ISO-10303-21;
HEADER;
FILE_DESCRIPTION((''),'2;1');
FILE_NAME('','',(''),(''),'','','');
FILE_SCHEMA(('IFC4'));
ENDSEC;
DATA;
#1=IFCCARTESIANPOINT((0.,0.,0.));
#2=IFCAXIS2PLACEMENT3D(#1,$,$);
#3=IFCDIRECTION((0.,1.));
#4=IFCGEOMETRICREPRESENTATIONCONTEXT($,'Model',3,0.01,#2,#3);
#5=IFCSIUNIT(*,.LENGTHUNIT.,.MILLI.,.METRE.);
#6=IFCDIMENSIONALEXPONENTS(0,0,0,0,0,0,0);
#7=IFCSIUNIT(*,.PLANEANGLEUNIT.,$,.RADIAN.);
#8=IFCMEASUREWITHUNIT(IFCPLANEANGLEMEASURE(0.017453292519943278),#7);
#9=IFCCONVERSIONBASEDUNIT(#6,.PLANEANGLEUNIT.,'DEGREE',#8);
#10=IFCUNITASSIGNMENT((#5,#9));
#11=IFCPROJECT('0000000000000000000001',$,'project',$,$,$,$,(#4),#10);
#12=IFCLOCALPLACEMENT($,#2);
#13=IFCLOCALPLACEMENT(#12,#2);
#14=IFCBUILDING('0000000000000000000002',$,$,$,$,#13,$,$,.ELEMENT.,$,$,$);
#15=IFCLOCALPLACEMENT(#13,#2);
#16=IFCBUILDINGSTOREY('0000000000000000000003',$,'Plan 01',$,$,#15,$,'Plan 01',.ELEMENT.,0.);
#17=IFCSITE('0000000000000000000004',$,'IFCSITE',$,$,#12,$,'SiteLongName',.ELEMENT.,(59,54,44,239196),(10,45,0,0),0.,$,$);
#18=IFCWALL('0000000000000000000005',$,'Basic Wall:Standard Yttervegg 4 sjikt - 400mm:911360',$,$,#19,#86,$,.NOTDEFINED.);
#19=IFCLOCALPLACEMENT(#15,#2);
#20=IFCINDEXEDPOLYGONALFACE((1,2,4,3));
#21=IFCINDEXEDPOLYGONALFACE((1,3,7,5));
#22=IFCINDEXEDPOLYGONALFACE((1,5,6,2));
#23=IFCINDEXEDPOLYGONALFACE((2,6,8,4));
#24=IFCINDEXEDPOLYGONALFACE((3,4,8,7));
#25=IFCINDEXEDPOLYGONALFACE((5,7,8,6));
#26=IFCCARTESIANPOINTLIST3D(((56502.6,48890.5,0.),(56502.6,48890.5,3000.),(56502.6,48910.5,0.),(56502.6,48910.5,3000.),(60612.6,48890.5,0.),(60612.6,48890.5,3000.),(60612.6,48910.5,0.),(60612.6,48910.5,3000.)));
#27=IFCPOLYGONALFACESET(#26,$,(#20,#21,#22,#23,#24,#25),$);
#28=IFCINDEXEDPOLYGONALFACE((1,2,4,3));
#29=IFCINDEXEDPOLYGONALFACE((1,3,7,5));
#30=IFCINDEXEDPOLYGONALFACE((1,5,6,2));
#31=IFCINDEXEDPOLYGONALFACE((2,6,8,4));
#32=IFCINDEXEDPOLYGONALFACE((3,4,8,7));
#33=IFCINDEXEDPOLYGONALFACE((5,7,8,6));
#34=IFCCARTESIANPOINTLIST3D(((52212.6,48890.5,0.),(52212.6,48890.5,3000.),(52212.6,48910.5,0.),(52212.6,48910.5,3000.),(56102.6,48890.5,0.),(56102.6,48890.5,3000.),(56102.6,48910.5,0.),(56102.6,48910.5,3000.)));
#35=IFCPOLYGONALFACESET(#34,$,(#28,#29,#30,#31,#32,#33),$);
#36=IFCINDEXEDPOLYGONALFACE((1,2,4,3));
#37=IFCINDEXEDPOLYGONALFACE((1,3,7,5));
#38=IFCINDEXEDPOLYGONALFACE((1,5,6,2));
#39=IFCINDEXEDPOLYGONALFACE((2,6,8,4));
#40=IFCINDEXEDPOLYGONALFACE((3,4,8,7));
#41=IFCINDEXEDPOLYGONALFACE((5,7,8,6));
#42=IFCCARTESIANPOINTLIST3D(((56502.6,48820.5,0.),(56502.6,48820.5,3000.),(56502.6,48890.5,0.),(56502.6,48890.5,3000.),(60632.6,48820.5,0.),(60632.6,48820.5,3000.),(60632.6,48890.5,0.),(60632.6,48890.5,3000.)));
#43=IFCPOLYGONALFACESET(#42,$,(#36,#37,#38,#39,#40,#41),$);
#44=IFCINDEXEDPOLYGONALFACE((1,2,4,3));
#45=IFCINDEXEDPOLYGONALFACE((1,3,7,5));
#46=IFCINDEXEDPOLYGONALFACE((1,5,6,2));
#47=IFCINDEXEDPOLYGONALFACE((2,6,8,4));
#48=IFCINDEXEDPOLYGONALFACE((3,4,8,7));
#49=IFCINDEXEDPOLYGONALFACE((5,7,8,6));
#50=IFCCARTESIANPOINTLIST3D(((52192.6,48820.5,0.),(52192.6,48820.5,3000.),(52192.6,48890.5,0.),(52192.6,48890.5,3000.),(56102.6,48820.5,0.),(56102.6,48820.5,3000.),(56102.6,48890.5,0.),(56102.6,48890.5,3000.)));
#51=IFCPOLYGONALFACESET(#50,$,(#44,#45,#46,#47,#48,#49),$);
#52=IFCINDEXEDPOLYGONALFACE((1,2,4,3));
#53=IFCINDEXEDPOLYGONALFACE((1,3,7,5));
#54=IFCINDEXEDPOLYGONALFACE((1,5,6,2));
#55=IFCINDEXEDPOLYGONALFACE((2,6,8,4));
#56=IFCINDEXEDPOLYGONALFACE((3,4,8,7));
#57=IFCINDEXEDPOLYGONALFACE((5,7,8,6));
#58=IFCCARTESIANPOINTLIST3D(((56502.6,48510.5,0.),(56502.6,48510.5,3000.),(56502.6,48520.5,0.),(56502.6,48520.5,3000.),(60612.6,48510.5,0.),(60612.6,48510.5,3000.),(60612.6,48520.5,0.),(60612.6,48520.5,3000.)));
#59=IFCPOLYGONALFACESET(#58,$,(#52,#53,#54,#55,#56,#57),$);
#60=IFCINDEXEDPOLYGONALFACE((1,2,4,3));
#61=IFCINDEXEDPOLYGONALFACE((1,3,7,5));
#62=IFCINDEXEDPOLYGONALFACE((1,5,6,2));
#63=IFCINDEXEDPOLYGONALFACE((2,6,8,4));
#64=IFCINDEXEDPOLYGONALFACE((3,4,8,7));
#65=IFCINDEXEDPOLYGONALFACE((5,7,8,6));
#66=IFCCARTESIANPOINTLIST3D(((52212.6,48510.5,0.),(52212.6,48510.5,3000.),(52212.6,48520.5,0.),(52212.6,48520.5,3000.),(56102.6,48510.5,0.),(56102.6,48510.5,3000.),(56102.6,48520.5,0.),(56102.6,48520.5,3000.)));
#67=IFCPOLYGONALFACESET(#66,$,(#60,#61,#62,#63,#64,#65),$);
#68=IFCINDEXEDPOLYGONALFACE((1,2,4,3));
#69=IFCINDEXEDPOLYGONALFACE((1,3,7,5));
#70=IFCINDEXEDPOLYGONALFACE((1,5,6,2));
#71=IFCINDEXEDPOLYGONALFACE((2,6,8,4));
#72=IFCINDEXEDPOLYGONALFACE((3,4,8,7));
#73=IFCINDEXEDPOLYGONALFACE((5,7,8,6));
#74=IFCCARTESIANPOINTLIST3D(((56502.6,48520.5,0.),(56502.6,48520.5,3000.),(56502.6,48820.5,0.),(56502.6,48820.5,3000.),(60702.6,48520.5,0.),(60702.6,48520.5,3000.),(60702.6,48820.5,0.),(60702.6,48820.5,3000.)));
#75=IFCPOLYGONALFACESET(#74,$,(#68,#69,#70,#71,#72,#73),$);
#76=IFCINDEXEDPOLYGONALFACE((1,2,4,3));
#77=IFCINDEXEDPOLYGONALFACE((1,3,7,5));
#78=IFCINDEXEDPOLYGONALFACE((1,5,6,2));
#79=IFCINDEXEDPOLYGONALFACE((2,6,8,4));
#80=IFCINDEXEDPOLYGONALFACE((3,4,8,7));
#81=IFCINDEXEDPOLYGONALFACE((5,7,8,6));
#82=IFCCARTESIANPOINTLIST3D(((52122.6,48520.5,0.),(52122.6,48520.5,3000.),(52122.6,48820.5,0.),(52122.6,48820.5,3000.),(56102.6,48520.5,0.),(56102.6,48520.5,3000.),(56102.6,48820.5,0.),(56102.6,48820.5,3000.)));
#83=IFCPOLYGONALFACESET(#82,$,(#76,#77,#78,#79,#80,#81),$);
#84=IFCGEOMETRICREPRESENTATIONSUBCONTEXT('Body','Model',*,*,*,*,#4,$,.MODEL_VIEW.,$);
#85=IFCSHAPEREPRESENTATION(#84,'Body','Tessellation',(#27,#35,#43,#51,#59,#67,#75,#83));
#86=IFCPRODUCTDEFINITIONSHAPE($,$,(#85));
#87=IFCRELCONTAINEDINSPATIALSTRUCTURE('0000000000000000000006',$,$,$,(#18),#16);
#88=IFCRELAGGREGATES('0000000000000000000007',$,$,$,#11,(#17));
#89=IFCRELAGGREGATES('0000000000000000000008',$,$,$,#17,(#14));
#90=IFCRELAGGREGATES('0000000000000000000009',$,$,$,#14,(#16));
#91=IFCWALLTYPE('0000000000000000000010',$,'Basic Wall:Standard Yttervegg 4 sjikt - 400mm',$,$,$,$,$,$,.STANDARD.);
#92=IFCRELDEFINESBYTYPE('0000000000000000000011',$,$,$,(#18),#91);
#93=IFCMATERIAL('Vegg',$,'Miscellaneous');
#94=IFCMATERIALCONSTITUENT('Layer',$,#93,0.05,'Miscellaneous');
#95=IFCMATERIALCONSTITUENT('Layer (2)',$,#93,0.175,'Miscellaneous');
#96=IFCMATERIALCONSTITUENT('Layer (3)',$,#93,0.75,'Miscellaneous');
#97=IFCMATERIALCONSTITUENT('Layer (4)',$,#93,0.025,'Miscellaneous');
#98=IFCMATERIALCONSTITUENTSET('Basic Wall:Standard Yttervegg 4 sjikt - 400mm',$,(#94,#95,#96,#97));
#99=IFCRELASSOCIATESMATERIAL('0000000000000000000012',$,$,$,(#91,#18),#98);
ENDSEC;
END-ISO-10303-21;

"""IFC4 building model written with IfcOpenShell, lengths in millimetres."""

from ifc_helpers import new_model, entity, si_unit, converted_unit, direction, frame, origin, place, context, subcontext, project, spatial, indexed_curve, outline, extrude, material, constituent, constituent_set, type_object, element, save


model = new_model("IFC4")

# Units and contexts
model_context = context("Model", 3, precision=0.01, world=origin(), true_north=direction((0.0, 1.0)))
body_context = subcontext(model_context, "Body", "Model", "MODEL_VIEW")
ifc_project = project(units=[si_unit("LENGTHUNIT", "METRE", prefix="MILLI"), converted_unit("PLANEANGLEUNIT", "DEGREE", entity("IfcPlaneAngleMeasure", 0.017453292519943278), si_unit("PLANEANGLEUNIT", "RADIAN"), dimensions=[0, 0, 0, 0, 0, 0, 0])], contexts=[model_context])

# Site, building, storey
site_placement = place(None, origin())
site = spatial("IfcSite", under=ifc_project, at=site_placement, Name="IFCSITE", LongName="SiteLongName", CompositionType="ELEMENT", RefLatitude=(59, 54, 44, 239196), RefLongitude=(10, 45, 0, 0), RefElevation=0.0)
building_placement = place(site_placement, origin())
building = spatial("IfcBuilding", under=site, at=building_placement, CompositionType="ELEMENT")
storey_placement = place(building_placement, origin())
storey = spatial("IfcBuildingStorey", under=building, at=storey_placement, Name="Plan 01", LongName="Plan 01", CompositionType="ELEMENT", Elevation=0.0)

# Wall
ifc_material_1 = material(Name="Vegg", Category="Miscellaneous")
ifc_constituent_1 = constituent(ifc_material_1, Name="Layer", Category="Miscellaneous", fraction=0.05)
ifc_constituent_2 = constituent(ifc_material_1, Name="Layer (2)", Category="Miscellaneous", fraction=0.175)
ifc_constituent_3 = constituent(ifc_material_1, Name="Layer (3)", Category="Miscellaneous", fraction=0.75)
ifc_constituent_4 = constituent(ifc_material_1, Name="Layer (4)", Category="Miscellaneous", fraction=0.025)
ifc_constituent_set_1 = constituent_set(constituents=[ifc_constituent_1, ifc_constituent_2, ifc_constituent_3, ifc_constituent_4], Name="Basic Wall:Standard Yttervegg 4 sjikt - 400mm")
wall_type = type_object("IfcWallType", Name="Basic Wall:Standard Yttervegg 4 sjikt - 400mm", PredefinedType="STANDARD", material=ifc_constituent_set_1)
wall_1_placement = place(storey_placement, frame((52212.6, 48710.5, 0.0)))
element("IfcWall", 1, at=wall_1_placement, inside=storey, type_object=wall_type, material=ifc_constituent_set_1, Name="Basic Wall:Standard Yttervegg 4 sjikt - 400mm:911360", PredefinedType="NOTDEFINED", context=body_context, shape_type="SweptSolid", body=[
    extrude(outline(indexed_curve([(-10.0, -2055.0), (10.0, -2055.0), (10.0, 2055.0), (-10.0, 2055.0), (-10.0, -2055.0)], self_intersect=False)), frame((6345.0, 190.0, 0.0), z_axis=(0.0, 0.0, 1.0), x_axis=(0.0, -1.0, 0.0)), (0.0, 0.0, 1.0), 3000.0),
    extrude(outline(indexed_curve([(-10.0, -1945.0), (10.0, -1945.0), (10.0, 1945.0), (-10.0, 1945.0), (-10.0, -1945.0)], self_intersect=False)), frame((1945.0, 190.0, 0.0), z_axis=(0.0, 0.0, 1.0), x_axis=(0.0, -1.0, 0.0)), (0.0, 0.0, 1.0), 3000.0),
    extrude(outline(indexed_curve([(-2065.0, -35.0), (2065.0, -35.0), (2065.0, 35.0), (-2065.0, 35.0), (-2065.0, -35.0)], self_intersect=False)), frame((6355.0, 145.0, 0.0), z_axis=(0.0, 0.0, 1.0), x_axis=(-1.0, 0.0, 0.0)), (0.0, 0.0, 1.0), 3000.0),
    extrude(outline(indexed_curve([(-1955.0, -35.0), (1955.0, -35.0), (1955.0, 35.0), (-1955.0, 35.0), (-1955.0, -35.0)], self_intersect=False)), frame((1935.0, 145.0, 0.0)), (0.0, 0.0, 1.0), 3000.0),
    extrude(outline(indexed_curve([(-5.0, -2055.0), (5.0, -2055.0), (5.0, 2055.0), (-5.0, 2055.0), (-5.0, -2055.0)], self_intersect=False)), frame((6345.0, -195.0, 0.0), z_axis=(0.0, 0.0, 1.0), x_axis=(0.0, 1.0, 0.0)), (0.0, 0.0, 1.0), 3000.0),
    extrude(outline(indexed_curve([(-5.0, -1945.0), (5.0, -1945.0), (5.0, 1945.0), (-5.0, 1945.0), (-5.0, -1945.0)], self_intersect=False)), frame((1945.0, -195.0, 0.0), z_axis=(0.0, 0.0, 1.0), x_axis=(0.0, 1.0, 0.0)), (0.0, 0.0, 1.0), 3000.0),
    extrude(outline(indexed_curve([(-2100.0, -150.0), (2100.0, -150.0), (2100.0, 150.0), (-2100.0, 150.0), (-2100.0, -150.0)], self_intersect=False)), frame((6390.0, -40.0, 0.0), z_axis=(0.0, 0.0, 1.0), x_axis=(-1.0, 0.0, 0.0)), (0.0, 0.0, 1.0), 3000.0),
    extrude(outline(indexed_curve([(-1990.0, -150.0), (1990.0, -150.0), (1990.0, 150.0), (-1990.0, 150.0), (-1990.0, -150.0)], self_intersect=False)), frame((1900.0, -40.0, 0.0)), (0.0, 0.0, 1.0), 3000.0),
])

save(model, "model.ifc")
